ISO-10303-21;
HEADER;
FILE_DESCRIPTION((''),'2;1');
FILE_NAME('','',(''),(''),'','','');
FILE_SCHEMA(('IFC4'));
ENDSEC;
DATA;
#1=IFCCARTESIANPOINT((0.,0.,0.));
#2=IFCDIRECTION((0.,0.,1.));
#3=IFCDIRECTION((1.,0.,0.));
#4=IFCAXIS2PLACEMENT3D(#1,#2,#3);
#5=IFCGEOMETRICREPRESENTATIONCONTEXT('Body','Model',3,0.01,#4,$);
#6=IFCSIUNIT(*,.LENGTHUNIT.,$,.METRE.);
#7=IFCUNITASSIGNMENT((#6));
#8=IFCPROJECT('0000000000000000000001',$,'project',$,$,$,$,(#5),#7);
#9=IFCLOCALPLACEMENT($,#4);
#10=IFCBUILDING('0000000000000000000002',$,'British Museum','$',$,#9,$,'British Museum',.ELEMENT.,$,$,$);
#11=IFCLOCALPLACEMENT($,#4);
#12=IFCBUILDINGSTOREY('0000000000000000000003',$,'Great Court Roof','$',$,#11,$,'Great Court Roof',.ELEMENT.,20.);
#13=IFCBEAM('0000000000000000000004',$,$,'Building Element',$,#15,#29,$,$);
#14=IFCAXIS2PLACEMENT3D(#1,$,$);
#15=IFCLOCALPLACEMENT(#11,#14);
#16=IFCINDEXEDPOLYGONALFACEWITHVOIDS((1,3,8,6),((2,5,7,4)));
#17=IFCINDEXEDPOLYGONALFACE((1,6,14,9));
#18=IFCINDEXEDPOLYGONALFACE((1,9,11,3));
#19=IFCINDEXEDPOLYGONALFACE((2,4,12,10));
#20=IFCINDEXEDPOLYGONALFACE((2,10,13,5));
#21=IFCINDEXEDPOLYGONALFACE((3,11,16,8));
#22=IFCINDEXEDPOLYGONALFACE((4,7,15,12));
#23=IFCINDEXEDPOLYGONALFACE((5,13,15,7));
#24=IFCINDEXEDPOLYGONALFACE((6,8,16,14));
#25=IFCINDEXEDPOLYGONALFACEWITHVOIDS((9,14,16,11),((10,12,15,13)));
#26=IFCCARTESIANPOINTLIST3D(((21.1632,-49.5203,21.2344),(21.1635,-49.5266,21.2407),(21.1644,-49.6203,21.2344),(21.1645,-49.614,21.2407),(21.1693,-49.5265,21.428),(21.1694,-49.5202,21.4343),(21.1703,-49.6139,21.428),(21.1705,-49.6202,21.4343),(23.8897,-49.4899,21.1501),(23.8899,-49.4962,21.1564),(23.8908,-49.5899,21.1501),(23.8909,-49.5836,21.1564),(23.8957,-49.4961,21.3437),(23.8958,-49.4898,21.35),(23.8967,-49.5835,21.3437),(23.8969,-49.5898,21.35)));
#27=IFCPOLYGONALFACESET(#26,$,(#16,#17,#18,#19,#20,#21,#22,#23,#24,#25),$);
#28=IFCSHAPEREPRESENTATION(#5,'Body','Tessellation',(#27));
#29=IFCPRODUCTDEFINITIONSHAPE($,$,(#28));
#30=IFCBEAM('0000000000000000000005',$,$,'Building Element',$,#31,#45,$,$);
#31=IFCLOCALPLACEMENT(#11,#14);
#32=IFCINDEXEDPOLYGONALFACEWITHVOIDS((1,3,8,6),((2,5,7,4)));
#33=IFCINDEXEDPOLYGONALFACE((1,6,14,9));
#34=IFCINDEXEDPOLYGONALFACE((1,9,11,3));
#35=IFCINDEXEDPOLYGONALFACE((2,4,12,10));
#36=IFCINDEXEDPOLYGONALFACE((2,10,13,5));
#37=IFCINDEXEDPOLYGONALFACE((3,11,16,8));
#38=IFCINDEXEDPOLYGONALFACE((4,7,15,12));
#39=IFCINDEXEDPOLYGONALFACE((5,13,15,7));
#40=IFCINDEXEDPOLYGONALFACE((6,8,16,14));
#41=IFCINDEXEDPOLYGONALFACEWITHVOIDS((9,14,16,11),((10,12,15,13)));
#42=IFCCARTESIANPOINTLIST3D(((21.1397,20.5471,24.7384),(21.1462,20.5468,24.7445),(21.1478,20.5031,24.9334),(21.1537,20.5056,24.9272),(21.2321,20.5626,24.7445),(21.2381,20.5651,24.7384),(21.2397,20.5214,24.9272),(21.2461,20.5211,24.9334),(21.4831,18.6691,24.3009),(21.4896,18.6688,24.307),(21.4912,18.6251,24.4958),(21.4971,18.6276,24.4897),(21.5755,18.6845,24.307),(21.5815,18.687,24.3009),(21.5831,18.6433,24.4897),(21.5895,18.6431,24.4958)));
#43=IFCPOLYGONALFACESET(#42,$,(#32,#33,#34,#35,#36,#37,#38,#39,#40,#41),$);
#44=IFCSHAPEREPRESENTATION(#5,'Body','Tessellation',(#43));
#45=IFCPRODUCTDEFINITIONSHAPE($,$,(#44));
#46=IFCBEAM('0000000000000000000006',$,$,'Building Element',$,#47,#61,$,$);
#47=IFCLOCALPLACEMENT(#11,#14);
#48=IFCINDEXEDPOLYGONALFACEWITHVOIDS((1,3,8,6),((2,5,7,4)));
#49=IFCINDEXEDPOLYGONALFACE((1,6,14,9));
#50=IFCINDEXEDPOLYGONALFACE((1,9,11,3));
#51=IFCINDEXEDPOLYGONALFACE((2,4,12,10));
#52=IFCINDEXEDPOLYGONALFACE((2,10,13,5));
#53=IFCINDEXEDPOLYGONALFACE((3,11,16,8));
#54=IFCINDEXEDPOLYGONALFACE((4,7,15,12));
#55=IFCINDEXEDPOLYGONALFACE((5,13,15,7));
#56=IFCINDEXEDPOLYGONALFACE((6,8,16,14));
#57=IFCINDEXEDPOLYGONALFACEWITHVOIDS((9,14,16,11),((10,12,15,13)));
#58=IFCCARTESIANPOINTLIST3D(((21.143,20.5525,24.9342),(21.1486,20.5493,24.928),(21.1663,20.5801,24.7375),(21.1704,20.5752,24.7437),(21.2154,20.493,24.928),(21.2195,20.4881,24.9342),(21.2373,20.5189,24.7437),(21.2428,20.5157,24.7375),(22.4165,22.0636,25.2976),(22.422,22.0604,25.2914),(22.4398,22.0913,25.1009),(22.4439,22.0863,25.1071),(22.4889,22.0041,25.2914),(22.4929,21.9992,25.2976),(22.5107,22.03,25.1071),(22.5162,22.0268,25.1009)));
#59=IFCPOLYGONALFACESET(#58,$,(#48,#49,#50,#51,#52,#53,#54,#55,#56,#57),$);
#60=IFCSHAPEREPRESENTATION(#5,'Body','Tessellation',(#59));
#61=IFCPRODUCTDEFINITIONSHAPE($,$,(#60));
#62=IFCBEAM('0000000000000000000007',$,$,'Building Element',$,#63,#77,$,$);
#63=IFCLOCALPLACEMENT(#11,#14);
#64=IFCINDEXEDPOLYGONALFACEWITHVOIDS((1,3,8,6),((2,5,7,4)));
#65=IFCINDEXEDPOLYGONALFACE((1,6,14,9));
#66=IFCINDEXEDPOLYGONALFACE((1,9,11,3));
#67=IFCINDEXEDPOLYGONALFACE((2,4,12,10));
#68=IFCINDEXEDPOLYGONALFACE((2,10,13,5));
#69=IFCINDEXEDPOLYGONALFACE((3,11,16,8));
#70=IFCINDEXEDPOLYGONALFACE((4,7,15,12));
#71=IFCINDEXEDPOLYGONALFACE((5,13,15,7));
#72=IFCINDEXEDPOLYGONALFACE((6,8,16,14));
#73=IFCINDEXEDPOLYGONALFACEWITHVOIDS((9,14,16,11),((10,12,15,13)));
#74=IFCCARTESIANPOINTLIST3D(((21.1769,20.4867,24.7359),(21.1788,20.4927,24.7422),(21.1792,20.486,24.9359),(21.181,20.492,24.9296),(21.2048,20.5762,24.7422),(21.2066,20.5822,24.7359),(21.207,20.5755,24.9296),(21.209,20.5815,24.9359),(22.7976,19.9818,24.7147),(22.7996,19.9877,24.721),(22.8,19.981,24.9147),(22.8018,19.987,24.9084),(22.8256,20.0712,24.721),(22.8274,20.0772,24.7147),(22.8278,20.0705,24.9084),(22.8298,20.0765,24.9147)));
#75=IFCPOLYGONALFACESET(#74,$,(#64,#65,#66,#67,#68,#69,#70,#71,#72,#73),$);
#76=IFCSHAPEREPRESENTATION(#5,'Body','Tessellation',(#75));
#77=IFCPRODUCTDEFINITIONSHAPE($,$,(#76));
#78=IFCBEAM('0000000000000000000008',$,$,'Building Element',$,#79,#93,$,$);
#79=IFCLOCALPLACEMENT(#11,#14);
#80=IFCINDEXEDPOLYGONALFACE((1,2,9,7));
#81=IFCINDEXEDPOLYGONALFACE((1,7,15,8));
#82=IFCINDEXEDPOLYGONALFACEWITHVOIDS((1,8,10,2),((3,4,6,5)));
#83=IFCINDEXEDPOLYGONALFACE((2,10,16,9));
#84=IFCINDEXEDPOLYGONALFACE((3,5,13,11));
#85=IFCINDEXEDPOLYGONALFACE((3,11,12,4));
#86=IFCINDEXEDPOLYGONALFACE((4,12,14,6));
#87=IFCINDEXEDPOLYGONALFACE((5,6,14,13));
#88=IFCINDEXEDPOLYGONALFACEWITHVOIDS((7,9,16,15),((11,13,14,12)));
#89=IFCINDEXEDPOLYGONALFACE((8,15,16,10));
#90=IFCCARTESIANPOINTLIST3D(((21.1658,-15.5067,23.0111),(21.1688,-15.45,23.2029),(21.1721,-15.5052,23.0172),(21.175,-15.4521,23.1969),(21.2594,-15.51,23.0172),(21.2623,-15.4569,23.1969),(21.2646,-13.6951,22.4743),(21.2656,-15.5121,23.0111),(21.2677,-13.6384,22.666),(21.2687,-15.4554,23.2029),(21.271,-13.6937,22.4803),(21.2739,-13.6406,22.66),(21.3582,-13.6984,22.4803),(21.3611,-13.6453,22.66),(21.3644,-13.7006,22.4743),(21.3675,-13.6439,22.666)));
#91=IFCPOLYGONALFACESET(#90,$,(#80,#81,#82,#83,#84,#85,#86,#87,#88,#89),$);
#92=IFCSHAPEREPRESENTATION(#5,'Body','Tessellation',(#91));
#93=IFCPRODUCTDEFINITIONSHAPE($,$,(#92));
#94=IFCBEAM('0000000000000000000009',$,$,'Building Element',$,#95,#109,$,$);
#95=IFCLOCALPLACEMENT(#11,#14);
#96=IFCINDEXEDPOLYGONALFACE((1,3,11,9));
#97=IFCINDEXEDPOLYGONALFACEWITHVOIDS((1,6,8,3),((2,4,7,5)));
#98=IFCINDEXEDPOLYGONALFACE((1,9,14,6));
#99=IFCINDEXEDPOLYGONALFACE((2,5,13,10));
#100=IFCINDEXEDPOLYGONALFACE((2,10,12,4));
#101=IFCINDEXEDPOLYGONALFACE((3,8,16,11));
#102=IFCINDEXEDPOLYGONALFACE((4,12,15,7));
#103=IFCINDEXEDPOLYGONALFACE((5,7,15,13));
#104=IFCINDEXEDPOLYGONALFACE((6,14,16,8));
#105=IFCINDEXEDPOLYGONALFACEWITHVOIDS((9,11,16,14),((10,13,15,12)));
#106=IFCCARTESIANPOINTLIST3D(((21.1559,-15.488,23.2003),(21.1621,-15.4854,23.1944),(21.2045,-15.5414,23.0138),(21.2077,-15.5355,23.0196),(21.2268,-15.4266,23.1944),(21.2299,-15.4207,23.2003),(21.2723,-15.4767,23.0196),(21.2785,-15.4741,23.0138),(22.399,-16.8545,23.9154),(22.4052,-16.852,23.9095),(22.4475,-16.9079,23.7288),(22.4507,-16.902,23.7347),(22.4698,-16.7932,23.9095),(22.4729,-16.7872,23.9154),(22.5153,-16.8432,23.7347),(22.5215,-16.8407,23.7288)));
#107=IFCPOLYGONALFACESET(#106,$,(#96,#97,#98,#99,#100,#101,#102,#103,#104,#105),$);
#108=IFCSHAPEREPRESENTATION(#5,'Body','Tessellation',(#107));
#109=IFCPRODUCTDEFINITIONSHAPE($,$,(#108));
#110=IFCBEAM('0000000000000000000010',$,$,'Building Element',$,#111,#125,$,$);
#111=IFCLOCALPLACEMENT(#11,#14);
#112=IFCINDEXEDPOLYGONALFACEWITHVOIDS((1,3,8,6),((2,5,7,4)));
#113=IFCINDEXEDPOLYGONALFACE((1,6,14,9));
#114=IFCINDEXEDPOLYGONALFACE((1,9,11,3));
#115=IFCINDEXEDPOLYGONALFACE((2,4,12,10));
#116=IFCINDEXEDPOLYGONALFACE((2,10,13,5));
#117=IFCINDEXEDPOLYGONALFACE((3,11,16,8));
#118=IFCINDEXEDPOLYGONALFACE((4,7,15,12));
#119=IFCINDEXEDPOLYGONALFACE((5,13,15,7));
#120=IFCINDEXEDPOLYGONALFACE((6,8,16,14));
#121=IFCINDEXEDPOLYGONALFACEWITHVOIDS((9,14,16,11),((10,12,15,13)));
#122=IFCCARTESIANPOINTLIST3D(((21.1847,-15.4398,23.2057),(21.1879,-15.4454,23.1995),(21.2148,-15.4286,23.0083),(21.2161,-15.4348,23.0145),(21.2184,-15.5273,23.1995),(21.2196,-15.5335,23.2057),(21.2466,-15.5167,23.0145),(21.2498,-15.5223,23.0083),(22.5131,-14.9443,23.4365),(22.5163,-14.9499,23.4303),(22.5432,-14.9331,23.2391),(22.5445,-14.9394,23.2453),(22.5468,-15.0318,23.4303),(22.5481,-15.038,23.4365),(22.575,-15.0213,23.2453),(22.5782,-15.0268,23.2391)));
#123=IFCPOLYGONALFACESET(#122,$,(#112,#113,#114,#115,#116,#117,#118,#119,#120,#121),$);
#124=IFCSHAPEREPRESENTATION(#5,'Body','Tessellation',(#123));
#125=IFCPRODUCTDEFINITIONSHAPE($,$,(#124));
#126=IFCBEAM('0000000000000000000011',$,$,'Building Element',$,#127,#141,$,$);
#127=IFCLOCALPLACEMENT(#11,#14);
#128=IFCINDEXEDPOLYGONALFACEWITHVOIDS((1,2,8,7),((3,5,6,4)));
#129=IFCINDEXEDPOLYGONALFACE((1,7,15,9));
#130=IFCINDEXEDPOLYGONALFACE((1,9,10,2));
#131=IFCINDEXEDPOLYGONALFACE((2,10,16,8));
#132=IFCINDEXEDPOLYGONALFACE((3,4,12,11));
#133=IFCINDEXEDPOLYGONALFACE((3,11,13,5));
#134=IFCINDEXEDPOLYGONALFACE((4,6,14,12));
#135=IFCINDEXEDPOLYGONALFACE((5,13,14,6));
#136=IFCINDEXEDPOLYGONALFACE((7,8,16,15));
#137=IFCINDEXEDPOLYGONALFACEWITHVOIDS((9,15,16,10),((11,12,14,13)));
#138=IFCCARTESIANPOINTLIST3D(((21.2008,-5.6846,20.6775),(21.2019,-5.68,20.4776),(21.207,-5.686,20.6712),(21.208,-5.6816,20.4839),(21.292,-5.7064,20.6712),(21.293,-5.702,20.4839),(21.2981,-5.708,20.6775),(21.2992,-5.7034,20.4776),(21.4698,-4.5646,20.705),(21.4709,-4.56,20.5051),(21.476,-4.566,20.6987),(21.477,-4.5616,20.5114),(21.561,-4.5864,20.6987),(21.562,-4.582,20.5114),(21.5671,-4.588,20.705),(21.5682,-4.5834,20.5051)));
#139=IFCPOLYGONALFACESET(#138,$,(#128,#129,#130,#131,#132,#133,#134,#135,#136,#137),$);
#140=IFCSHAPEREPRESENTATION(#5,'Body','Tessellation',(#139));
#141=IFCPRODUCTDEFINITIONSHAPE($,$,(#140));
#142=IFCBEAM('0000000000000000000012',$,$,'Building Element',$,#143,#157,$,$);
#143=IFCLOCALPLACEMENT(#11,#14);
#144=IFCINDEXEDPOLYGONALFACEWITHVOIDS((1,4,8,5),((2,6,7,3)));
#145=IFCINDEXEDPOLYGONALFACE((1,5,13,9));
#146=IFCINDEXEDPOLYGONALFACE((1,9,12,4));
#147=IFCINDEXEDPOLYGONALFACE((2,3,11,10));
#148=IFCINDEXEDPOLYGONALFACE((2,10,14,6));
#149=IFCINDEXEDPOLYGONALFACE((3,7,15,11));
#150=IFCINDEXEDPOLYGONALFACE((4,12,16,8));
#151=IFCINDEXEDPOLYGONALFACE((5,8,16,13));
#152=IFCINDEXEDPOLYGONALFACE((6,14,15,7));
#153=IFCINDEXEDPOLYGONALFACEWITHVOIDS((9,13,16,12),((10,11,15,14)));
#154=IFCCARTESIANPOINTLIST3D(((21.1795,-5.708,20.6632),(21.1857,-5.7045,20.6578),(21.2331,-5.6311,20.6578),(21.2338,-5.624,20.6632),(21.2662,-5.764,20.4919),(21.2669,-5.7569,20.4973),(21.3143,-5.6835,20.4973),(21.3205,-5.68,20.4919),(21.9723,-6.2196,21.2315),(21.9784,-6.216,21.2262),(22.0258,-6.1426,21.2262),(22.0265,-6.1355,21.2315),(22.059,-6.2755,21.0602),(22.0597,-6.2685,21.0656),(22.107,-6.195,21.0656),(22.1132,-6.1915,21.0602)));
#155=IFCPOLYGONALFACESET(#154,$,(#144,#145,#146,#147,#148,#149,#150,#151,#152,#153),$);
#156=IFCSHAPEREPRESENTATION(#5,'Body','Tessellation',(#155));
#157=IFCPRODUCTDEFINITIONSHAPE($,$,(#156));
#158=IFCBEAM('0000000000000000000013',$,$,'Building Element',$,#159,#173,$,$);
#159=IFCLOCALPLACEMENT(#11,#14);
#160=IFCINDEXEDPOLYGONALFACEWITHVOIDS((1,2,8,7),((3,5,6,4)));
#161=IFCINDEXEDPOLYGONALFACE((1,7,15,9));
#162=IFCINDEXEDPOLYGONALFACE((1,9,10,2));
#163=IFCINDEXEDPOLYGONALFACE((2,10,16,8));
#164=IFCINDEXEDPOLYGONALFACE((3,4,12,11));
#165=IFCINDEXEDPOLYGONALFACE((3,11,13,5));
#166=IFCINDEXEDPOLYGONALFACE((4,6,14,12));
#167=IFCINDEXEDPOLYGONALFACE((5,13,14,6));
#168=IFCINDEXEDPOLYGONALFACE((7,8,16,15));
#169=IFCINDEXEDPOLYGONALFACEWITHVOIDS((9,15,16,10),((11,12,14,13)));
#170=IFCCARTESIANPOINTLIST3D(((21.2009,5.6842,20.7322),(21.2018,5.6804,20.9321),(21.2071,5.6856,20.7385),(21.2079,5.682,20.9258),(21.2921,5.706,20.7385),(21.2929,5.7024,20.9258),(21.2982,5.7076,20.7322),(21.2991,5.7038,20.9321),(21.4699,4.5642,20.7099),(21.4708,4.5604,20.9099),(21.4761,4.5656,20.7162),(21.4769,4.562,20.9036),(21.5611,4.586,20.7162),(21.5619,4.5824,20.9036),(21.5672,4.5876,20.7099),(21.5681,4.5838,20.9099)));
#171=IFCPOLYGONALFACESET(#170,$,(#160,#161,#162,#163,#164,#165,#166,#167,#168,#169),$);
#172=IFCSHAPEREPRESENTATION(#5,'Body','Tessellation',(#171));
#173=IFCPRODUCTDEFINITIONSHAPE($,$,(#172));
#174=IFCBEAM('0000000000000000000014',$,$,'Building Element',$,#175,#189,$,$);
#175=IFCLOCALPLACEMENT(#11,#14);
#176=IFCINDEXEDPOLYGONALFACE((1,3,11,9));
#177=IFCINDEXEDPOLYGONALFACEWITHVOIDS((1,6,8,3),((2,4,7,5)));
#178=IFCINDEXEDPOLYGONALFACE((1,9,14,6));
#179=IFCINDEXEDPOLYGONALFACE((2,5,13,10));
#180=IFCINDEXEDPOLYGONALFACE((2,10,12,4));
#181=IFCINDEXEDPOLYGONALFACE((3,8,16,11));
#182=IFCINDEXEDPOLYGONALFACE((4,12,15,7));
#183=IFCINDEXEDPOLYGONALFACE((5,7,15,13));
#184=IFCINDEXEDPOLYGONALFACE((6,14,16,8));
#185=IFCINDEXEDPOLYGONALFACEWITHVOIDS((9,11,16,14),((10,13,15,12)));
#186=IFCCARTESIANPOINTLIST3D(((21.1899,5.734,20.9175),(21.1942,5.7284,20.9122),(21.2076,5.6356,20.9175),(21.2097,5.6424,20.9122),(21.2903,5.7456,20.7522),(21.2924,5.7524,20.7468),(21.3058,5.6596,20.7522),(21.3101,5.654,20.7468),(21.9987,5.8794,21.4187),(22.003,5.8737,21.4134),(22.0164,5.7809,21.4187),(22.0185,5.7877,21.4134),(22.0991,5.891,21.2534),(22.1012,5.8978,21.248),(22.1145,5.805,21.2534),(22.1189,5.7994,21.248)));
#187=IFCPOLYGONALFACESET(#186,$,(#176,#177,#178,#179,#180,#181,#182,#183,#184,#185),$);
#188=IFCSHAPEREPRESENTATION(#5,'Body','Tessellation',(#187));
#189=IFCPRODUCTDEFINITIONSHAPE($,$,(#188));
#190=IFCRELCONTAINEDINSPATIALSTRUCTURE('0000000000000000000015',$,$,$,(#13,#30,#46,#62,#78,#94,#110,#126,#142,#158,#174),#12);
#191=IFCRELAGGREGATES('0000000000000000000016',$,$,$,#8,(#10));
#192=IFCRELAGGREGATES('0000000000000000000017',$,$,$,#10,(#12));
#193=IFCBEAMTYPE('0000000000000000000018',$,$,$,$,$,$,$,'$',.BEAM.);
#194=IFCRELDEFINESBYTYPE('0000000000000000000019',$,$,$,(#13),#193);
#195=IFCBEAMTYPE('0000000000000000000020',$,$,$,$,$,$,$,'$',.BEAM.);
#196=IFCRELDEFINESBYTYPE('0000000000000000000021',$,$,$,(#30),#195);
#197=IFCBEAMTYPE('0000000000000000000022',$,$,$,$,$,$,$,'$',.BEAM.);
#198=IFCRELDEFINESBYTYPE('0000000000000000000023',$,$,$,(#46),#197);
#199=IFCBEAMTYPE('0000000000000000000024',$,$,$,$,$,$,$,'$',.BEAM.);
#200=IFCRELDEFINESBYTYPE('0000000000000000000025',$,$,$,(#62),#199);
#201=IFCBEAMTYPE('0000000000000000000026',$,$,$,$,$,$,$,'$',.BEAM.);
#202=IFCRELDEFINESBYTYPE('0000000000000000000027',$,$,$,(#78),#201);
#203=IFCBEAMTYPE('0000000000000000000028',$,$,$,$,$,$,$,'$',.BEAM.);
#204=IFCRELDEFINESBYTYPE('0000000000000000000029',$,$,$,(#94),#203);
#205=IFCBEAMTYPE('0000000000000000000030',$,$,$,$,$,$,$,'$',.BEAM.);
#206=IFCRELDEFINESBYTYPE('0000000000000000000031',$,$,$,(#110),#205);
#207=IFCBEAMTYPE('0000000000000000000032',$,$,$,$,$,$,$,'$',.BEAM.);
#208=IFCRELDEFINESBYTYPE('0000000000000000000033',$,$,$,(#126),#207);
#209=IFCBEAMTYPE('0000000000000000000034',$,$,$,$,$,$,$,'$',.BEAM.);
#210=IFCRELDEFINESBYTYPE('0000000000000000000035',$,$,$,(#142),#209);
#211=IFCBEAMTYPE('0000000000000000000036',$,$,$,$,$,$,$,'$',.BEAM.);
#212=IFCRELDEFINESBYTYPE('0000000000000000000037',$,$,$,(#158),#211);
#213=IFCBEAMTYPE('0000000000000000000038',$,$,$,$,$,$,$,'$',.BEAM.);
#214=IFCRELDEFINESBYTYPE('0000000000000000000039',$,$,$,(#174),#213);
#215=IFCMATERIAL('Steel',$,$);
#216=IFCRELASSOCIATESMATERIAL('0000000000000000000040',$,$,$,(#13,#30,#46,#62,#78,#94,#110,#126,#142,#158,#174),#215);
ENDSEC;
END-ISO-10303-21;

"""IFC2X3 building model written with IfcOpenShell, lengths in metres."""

from ifc_helpers import new_model, si_unit, frame, origin_with_axes, origin_2d, place, context, project, spatial, hollow_rectangle, extrude, material, type_object, element, save


model = new_model("IFC2X3")

# Units and contexts
model_context = context("Model", 3, precision=0.01, world=origin_with_axes(), identifier="Body")
ifc_project = project(units=[si_unit("LENGTHUNIT", "METRE")], contexts=[model_context])

# Building, storey
building_placement = place(None, origin_with_axes())
building = spatial("IfcBuilding", under=ifc_project, at=building_placement, Name="British Museum", Description="$", LongName="British Museum", CompositionType="ELEMENT")
storey_placement = place(None, origin_with_axes())
storey = spatial("IfcBuildingStorey", under=building, at=storey_placement, Name="Great Court Roof", Description="$", LongName="Great Court Roof", CompositionType="ELEMENT", Elevation=20.0)

# Beams
ifc_material = material(Name="Steel")
beam_type_1 = type_object("IfcBeamType", ElementType="$", PredefinedType="BEAM")
beam_1_placement = place(None, origin_with_axes())
element("IfcBeam", 1, at=beam_1_placement, inside=storey, type_object=beam_type_1, material=ifc_material, Description="Building Element", context=model_context, shape_type="SweptSolid", body=[
    extrude(hollow_rectangle(XDim=0.1, YDim=0.2, WallThickness=0.0063, InnerFilletRadius=-0.0063, OuterFilletRadius=0.0, at=origin_2d()), frame((21.1669, -49.5702, 21.3343), z_axis=(0.999461, 0.011137, -0.030874), x_axis=(-0.011142, 0.999938, 0.0)), (0.0, 0.0, 1.0), 2.7279),
])
beam_type_2 = type_object("IfcBeamType", ElementType="$", PredefinedType="BEAM")
beam_2_placement = place(None, origin_with_axes())
element("IfcBeam", 2, at=beam_2_placement, inside=storey, type_object=beam_type_2, material=ifc_material, Description="Building Element", context=model_context, shape_type="SweptSolid", body=[
    extrude(hollow_rectangle(XDim=0.1, YDim=0.2, WallThickness=0.0063, InnerFilletRadius=-0.0063, OuterFilletRadius=0.0, at=origin_2d()), frame((21.1929, 20.5341, 24.8359), z_axis=(0.175323, -0.958833, -0.223387), x_axis=(0.983691, 0.179868, 0.0)), (0.0, 0.0, 1.0), 1.9587),
])
beam_type_3 = type_object("IfcBeamType", ElementType="$", PredefinedType="BEAM")
beam_3_placement = place(None, origin_with_axes())
element("IfcBeam", 3, at=beam_3_placement, inside=storey, type_object=beam_type_3, material=ifc_material, Description="Building Element", context=model_context, shape_type="SweptSolid", body=[
    extrude(hollow_rectangle(XDim=0.1, YDim=0.2, WallThickness=0.0063, InnerFilletRadius=-0.0063, OuterFilletRadius=0.0, at=origin_2d()), frame((21.1929, 20.5341, 24.8359), z_axis=(0.63378, 0.752076, 0.180841), x_axis=(-0.764684, 0.644405, 0.0)), (0.0, 0.0, 1.0), 2.0093),
])
beam_type_4 = type_object("IfcBeamType", ElementType="$", PredefinedType="BEAM")
beam_4_placement = place(None, origin_with_axes())
element("IfcBeam", 4, at=beam_4_placement, inside=storey, type_object=beam_type_4, material=ifc_material, Description="Building Element", context=model_context, shape_type="SweptSolid", body=[
    extrude(hollow_rectangle(XDim=0.1, YDim=0.2, WallThickness=0.0063, InnerFilletRadius=-0.0063, OuterFilletRadius=0.0, at=origin_2d()), frame((21.1929, 20.5341, 24.8359), z_axis=(0.954659, -0.297441, -0.012467), x_axis=(0.297465, 0.954733, 0.0)), (0.0, 0.0, 1.0), 1.6978),
])
beam_type_5 = type_object("IfcBeamType", ElementType="$", PredefinedType="BEAM")
beam_5_placement = place(None, origin_with_axes())
element("IfcBeam", 5, at=beam_5_placement, inside=storey, type_object=beam_type_5, material=ifc_material, Description="Building Element", context=model_context, shape_type="SweptSolid", body=[
    extrude(hollow_rectangle(XDim=0.1, YDim=0.2, WallThickness=0.0063, InnerFilletRadius=-0.0063, OuterFilletRadius=0.0, at=origin_2d()), frame((21.2172, -15.4811, 23.107), z_axis=(0.05223, 0.957472, -0.283761), x_axis=(-0.998515, 0.054469, 0.0)), (0.0, 0.0, 1.0), 1.892),
])
beam_type_6 = type_object("IfcBeamType", ElementType="$", PredefinedType="BEAM")
beam_6_placement = place(None, origin_with_axes())
element("IfcBeam", 6, at=beam_6_placement, inside=storey, type_object=beam_type_6, material=ifc_material, Description="Building Element", context=model_context, shape_type="SweptSolid", body=[
    extrude(hollow_rectangle(XDim=0.1, YDim=0.2, WallThickness=0.0063, InnerFilletRadius=-0.0063, OuterFilletRadius=0.0, at=origin_2d()), frame((21.2172, -15.4811, 23.107), z_axis=(0.627508, -0.68987, 0.36099), x_axis=(0.739751, 0.67288, 0.0)), (0.0, 0.0, 1.0), 1.9809),
])
beam_type_7 = type_object("IfcBeamType", ElementType="$", PredefinedType="BEAM")
beam_7_placement = place(None, origin_with_axes())
element("IfcBeam", 7, at=beam_7_placement, inside=storey, type_object=beam_type_7, material=ifc_material, Description="Building Element", context=model_context, shape_type="SweptSolid", body=[
    extrude(hollow_rectangle(XDim=0.1, YDim=0.2, WallThickness=0.0063, InnerFilletRadius=-0.0063, OuterFilletRadius=0.0, at=origin_2d()), frame((21.2172, -15.4811, 23.107), z_axis=(0.924782, 0.344924, 0.160643), x_axis=(-0.349463, 0.93695, 0.0)), (0.0, 0.0, 1.0), 1.4365),
])
beam_type_8 = type_object("IfcBeamType", ElementType="$", PredefinedType="BEAM")
beam_8_placement = place(None, origin_with_axes())
element("IfcBeam", 8, at=beam_8_placement, inside=storey, type_object=beam_type_8, material=ifc_material, Description="Building Element", context=model_context, shape_type="SweptSolid", body=[
    extrude(hollow_rectangle(XDim=0.1, YDim=0.2, WallThickness=0.0063, InnerFilletRadius=-0.0063, OuterFilletRadius=0.0, at=origin_2d()), frame((21.25, -5.694, 20.5775), z_axis=(0.23347, 0.97207, 0.023903), x_axis=(-0.972348, 0.233536, 0.0)), (0.0, 0.0, 1.0), 1.1522),
])
beam_type_9 = type_object("IfcBeamType", ElementType="$", PredefinedType="BEAM")
beam_9_placement = place(None, origin_with_axes())
element("IfcBeam", 9, at=beam_9_placement, inside=storey, type_object=beam_type_9, material=ifc_material, Description="Building Element", context=model_context, shape_type="SweptSolid", body=[
    extrude(hollow_rectangle(XDim=0.1, YDim=0.2, WallThickness=0.0063, InnerFilletRadius=-0.0063, OuterFilletRadius=0.0, at=origin_2d()), frame((21.25, -5.694, 20.5775), z_axis=(0.719736, -0.464432, 0.516025), x_axis=(0.542198, 0.840251, 0.0)), (0.0, 0.0, 1.0), 1.1014),
])
beam_type_10 = type_object("IfcBeamType", ElementType="$", PredefinedType="BEAM")
beam_10_placement = place(None, origin_with_axes())
element("IfcBeam", 10, at=beam_10_placement, inside=storey, type_object=beam_type_10, material=ifc_material, Description="Building Element", context=model_context, shape_type="SweptSolid", body=[
    extrude(hollow_rectangle(XDim=0.1, YDim=0.2, WallThickness=0.0063, InnerFilletRadius=-0.0063, OuterFilletRadius=0.0, at=origin_2d()), frame((21.25, 5.694, 20.8322), z_axis=(0.233493, -0.972166, -0.019341), x_axis=(0.972348, 0.233536, 0.0)), (0.0, 0.0, 1.0), 1.1521),
])
beam_type_11 = type_object("IfcBeamType", ElementType="$", PredefinedType="BEAM")
beam_11_placement = place(None, origin_with_axes())
element("IfcBeam", 11, at=beam_11_placement, inside=storey, type_object=beam_type_11, material=ifc_material, Description="Building Element", context=model_context, shape_type="SweptSolid", body=[
    extrude(hollow_rectangle(XDim=0.1, YDim=0.2, WallThickness=0.0063, InnerFilletRadius=-0.0063, OuterFilletRadius=0.0, at=origin_2d()), frame((21.25, 5.694, 20.8322), z_axis=(0.840276, 0.151013, 0.520703), x_axis=(-0.176885, 0.984232, 0.0)), (0.0, 0.0, 1.0), 0.9625),
])

save(model, "model.ifc")
